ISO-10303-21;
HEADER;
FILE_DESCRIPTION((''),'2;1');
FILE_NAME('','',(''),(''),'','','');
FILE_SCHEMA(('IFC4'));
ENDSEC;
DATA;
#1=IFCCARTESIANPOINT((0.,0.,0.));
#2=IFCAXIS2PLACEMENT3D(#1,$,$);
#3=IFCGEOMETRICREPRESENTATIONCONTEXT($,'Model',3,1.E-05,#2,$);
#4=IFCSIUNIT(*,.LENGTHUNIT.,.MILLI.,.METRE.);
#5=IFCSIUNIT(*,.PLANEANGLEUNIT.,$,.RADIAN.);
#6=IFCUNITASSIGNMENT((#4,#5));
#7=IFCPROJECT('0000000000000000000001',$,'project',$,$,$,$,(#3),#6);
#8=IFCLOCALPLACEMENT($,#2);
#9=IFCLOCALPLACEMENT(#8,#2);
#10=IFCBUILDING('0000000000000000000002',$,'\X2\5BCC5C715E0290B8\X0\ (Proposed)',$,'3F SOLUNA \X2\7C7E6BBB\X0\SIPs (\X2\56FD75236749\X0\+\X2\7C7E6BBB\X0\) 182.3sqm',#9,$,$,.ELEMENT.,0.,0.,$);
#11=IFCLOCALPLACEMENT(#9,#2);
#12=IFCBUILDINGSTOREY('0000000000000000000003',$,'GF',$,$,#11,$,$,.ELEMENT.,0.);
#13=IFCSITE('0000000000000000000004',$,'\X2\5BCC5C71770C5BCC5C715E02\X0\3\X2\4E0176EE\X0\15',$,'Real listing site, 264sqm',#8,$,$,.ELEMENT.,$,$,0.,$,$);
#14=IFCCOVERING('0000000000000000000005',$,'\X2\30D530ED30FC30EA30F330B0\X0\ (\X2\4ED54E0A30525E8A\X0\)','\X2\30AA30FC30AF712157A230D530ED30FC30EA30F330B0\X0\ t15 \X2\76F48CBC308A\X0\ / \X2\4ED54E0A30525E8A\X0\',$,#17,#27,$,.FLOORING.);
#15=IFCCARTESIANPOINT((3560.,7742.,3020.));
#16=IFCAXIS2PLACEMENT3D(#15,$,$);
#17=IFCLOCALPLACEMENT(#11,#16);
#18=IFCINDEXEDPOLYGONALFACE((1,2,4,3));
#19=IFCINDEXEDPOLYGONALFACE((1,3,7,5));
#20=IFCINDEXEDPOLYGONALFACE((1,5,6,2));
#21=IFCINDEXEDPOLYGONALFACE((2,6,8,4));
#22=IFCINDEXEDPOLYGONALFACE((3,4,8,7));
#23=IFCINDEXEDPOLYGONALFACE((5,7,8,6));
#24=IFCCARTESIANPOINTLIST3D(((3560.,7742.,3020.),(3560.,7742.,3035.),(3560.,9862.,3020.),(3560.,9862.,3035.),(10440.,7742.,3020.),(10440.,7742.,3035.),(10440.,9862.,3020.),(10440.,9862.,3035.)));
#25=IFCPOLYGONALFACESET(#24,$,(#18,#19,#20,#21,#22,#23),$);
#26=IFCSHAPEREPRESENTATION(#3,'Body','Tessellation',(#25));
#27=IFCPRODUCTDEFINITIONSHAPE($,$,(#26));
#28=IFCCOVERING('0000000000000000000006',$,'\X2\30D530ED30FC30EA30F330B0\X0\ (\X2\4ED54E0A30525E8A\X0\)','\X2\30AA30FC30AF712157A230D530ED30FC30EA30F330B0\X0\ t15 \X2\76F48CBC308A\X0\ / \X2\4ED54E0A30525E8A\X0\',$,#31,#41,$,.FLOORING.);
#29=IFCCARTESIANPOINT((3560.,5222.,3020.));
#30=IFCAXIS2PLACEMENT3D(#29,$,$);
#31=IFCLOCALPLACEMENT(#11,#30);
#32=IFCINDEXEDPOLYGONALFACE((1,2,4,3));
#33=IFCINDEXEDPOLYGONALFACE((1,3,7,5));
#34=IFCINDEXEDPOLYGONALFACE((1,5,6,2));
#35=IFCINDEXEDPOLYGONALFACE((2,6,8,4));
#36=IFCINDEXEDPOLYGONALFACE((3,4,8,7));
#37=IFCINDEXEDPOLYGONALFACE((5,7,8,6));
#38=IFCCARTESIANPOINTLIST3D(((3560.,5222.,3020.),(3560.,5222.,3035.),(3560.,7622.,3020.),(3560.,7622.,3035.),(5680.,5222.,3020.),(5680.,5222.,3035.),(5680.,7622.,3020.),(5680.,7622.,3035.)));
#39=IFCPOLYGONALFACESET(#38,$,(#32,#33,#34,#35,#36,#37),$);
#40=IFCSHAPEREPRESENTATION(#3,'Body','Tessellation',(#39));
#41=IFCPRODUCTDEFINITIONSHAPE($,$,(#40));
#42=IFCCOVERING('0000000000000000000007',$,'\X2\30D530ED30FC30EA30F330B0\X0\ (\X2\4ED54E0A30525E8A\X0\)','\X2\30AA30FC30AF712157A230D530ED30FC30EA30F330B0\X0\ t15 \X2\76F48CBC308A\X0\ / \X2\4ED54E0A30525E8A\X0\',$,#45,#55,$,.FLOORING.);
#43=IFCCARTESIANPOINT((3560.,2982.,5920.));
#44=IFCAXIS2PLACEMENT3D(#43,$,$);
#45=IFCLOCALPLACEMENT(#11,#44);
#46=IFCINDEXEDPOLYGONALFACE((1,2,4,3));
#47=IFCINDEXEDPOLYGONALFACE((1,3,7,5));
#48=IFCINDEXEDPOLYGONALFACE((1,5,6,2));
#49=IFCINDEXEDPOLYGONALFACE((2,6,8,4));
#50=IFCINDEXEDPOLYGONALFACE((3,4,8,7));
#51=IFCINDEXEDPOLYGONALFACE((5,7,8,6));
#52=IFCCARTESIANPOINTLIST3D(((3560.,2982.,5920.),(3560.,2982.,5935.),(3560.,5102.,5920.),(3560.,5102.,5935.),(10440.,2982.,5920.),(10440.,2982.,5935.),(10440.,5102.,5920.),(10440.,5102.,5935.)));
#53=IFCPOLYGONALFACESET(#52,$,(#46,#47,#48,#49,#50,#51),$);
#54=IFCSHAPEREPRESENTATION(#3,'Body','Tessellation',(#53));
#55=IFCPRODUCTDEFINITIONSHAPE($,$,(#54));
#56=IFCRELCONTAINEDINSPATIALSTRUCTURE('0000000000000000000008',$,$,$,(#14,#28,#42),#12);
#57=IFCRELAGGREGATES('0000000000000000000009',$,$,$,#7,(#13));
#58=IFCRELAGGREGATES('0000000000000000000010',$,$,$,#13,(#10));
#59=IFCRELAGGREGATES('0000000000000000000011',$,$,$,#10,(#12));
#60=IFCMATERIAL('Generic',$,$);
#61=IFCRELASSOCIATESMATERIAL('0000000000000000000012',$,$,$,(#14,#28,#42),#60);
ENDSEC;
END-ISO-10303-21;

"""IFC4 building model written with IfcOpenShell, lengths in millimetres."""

from ifc_helpers import new_model, si_unit, frame, frame_2d, origin, place, context, project, spatial, rectangle, extrude, material, element, save


model = new_model("IFC4")

# Units and contexts
model_context = context("Model", 3, precision=1e-05, world=origin())
ifc_project = project(units=[si_unit("LENGTHUNIT", "METRE", prefix="MILLI"), si_unit("PLANEANGLEUNIT", "RADIAN")], contexts=[model_context])

# Site, building, storey
site_placement = place(None, origin())
site = spatial("IfcSite", under=ifc_project, at=site_placement, Name="富山県富山市3丁目15", ObjectType="Real listing site, 264sqm", CompositionType="ELEMENT", RefElevation=0.0)
building_placement = place(site_placement, origin())
building = spatial("IfcBuilding", under=site, at=building_placement, Name="富山市邸 (Proposed)", ObjectType="3F SOLUNA 籾殻SIPs (国産杉+籾殻) 182.3sqm", CompositionType="ELEMENT", ElevationOfRefHeight=0.0, ElevationOfTerrain=0.0)
storey_placement = place(building_placement, origin())
storey = spatial("IfcBuildingStorey", under=building, at=storey_placement, Name="GF", CompositionType="ELEMENT", Elevation=0.0)

# Shared definitions
ifc_material_1 = material(Name="Generic")

# Coverings
covering_1_placement = place(storey_placement, frame((3560.0, 7742.0, 3020.0)))
element("IfcCovering", 1, at=covering_1_placement, inside=storey, material=ifc_material_1, Name="フローリング (仕上げ床)", Description="オーク無垢フローリング t15 直貼り / 仕上げ床", PredefinedType="FLOORING", context=model_context, shape_type="SweptSolid", body=[
    extrude(rectangle(XDim=6880.0, YDim=2120.0, at=frame_2d((3440.0, 1060.0))), frame((3560.0, 7742.0, 3020.0)), (0.0, 0.0, 1.0), 15.0),
])
covering_2_placement = place(storey_placement, frame((3560.0, 5222.0, 3020.0)))
element("IfcCovering", 2, at=covering_2_placement, inside=storey, material=ifc_material_1, Name="フローリング (仕上げ床)", Description="オーク無垢フローリング t15 直貼り / 仕上げ床", PredefinedType="FLOORING", context=model_context, shape_type="SweptSolid", body=[
    extrude(rectangle(XDim=2120.0, YDim=2400.0, at=frame_2d((1060.0, 1200.0))), frame((3560.0, 5222.0, 3020.0)), (0.0, 0.0, 1.0), 15.0),
])
covering_3_placement = place(storey_placement, frame((3560.0, 2982.0, 5920.0)))
element("IfcCovering", 3, at=covering_3_placement, inside=storey, material=ifc_material_1, Name="フローリング (仕上げ床)", Description="オーク無垢フローリング t15 直貼り / 仕上げ床", PredefinedType="FLOORING", context=model_context, shape_type="SweptSolid", body=[
    extrude(rectangle(XDim=6880.0, YDim=2120.0, at=frame_2d((3440.0, 1060.0))), frame((3560.0, 2982.0, 5920.0)), (0.0, 0.0, 1.0), 15.0),
])

save(model, "model.ifc")
